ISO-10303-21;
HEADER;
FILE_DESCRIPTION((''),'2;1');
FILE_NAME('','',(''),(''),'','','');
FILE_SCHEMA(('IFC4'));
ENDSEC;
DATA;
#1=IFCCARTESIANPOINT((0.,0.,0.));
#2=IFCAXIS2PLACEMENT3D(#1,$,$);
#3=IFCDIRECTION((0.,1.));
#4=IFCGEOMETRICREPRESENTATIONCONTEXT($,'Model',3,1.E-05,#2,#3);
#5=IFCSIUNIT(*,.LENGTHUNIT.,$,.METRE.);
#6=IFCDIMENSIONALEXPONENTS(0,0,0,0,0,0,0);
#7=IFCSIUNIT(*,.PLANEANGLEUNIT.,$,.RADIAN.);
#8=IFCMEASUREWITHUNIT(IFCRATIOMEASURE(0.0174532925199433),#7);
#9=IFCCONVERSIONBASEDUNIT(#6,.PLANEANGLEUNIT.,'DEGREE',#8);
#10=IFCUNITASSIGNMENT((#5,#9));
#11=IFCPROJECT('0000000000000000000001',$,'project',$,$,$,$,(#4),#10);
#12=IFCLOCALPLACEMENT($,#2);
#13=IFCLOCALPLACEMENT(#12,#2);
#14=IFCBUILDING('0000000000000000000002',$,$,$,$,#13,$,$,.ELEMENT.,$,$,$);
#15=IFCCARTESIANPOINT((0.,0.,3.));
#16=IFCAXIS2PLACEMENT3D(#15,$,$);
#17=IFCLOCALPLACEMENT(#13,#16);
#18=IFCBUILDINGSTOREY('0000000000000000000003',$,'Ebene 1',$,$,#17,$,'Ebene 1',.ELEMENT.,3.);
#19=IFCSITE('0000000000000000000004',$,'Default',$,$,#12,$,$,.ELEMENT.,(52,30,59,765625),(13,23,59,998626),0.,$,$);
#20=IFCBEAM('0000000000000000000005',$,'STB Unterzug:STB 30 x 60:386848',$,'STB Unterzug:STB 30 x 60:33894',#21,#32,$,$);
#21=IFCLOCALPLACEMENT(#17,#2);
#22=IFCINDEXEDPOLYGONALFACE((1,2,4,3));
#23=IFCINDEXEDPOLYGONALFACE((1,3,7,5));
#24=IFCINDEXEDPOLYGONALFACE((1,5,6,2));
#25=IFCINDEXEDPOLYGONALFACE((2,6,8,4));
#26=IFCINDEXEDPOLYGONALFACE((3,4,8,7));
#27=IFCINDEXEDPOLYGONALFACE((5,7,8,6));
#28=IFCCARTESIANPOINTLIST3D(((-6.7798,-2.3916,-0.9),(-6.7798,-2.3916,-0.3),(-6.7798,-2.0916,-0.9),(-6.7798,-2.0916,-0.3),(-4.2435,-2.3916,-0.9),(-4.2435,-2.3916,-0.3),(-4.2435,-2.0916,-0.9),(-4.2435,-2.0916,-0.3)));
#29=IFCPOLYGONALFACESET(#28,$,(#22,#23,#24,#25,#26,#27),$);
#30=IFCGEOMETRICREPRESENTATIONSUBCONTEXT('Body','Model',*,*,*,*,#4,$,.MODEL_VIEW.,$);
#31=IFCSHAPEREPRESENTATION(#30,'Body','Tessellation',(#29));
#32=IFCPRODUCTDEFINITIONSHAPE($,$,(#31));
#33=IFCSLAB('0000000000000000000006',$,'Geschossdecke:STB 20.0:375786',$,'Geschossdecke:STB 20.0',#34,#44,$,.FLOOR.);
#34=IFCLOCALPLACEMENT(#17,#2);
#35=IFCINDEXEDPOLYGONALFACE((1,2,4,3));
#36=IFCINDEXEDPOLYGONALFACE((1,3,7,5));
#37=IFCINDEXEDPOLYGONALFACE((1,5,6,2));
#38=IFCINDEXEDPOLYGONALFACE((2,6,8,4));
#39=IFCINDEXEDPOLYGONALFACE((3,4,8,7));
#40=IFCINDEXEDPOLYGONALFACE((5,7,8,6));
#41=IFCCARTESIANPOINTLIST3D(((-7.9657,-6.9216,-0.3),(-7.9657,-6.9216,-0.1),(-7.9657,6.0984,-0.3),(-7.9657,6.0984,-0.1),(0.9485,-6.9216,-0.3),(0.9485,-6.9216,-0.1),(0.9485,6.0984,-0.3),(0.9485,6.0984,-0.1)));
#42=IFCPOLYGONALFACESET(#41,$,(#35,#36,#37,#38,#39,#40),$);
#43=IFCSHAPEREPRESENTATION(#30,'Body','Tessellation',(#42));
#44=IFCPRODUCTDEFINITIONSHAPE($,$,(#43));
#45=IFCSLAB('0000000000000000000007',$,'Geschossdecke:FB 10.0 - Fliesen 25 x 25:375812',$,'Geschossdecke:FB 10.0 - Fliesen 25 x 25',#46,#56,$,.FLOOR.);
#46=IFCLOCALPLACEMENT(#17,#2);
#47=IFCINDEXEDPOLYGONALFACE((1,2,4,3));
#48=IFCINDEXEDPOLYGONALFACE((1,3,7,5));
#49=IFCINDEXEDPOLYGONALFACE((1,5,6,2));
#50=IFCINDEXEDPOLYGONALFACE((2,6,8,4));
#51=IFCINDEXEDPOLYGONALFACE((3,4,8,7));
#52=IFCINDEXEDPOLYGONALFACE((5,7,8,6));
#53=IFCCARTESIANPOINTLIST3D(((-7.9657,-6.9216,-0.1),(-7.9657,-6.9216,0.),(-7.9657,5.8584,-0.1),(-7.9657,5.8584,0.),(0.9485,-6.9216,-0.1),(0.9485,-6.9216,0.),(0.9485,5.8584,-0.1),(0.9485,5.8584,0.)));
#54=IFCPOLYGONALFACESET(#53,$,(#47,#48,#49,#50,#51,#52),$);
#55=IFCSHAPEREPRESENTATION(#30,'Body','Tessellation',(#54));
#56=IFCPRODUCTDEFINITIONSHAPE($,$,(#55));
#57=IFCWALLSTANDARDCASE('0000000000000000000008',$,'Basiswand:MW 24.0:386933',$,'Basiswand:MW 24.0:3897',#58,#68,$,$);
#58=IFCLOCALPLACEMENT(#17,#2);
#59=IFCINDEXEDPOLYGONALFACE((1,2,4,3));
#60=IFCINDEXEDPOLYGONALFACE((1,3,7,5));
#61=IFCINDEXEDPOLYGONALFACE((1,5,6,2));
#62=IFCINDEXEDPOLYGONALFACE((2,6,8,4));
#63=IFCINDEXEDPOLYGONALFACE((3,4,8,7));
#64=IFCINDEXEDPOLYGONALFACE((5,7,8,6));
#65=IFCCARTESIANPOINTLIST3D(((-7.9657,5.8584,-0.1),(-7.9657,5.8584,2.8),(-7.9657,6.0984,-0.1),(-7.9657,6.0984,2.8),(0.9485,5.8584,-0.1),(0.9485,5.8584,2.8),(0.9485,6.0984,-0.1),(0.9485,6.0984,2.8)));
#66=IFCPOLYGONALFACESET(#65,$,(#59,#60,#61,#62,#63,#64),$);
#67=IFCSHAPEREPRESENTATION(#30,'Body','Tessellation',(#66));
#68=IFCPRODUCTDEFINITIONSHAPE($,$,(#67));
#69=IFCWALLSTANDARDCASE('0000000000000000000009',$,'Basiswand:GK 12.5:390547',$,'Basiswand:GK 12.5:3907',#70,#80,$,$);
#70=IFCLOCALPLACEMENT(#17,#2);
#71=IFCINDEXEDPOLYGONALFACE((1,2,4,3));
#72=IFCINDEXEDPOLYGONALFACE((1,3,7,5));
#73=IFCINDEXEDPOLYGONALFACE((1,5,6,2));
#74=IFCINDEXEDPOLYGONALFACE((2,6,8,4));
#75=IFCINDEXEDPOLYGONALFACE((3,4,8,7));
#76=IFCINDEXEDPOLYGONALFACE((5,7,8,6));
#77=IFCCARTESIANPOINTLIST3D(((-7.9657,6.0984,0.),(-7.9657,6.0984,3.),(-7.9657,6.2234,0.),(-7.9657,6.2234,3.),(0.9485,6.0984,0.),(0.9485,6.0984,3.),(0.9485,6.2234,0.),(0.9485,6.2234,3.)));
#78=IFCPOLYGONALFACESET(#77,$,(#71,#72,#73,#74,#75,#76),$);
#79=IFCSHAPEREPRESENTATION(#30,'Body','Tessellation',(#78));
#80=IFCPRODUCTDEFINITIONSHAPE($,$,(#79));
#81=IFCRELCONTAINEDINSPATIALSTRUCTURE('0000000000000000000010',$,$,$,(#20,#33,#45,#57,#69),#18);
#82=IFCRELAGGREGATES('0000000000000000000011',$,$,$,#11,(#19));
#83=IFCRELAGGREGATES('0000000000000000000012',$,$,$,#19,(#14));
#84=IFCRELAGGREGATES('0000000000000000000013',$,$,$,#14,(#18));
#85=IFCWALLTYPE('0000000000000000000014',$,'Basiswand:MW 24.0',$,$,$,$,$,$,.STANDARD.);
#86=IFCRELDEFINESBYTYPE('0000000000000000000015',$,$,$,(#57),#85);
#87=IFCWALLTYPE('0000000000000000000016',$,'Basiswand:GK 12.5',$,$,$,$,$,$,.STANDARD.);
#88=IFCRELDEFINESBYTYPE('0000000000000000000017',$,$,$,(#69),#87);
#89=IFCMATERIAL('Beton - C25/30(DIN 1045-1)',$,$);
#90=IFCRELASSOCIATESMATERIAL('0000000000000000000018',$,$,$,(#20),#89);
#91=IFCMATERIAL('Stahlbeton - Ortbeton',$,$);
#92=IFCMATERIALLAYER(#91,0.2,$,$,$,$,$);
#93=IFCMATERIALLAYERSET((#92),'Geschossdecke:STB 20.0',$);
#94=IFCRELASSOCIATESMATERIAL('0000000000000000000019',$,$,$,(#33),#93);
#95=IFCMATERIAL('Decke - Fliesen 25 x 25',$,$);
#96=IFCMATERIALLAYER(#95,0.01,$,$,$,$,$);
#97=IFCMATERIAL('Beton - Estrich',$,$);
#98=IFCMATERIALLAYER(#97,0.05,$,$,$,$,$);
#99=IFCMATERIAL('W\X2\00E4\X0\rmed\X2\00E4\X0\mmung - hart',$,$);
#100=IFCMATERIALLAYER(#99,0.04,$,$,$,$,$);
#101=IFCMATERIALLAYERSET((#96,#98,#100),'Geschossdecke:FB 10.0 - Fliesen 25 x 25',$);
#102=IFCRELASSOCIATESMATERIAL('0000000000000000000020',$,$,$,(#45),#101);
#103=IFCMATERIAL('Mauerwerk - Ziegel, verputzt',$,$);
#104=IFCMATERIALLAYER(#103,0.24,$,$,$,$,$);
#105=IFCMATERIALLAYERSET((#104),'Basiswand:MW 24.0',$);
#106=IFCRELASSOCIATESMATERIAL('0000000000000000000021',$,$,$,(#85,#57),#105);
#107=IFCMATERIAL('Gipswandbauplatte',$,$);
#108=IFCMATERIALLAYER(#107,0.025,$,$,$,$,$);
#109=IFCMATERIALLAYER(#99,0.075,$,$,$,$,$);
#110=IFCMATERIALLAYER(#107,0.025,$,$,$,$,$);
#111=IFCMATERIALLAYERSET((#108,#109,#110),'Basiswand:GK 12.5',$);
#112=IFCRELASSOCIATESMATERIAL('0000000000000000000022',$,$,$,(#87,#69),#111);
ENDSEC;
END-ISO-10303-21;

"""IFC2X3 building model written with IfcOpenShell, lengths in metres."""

from ifc_helpers import new_model, entity, si_unit, converted_unit, direction, frame, frame_2d, origin, origin_2d_with_axis, place, context, subcontext, project, spatial, polyline, rectangle, extrude, clip, bounded_halfspace, material, layer, layer_set, layer_usage, type_object, element, save


model = new_model("IFC2X3")

# Units and contexts
model_context = context("Model", 3, precision=1e-05, world=origin(), true_north=direction((0.0, 1.0)))
body_context = subcontext(model_context, "Body", "Model", "MODEL_VIEW")
ifc_project = project(units=[si_unit("LENGTHUNIT", "METRE"), converted_unit("PLANEANGLEUNIT", "DEGREE", entity("IfcRatioMeasure", 0.0174532925199433), si_unit("PLANEANGLEUNIT", "RADIAN"), dimensions=[0, 0, 0, 0, 0, 0, 0])], contexts=[model_context])

# Site, building, storey
site_placement = place(None, origin())
site = spatial("IfcSite", under=ifc_project, at=site_placement, Name="Default", CompositionType="ELEMENT", RefLatitude=(52, 30, 59, 765625), RefLongitude=(13, 23, 59, 998626), RefElevation=0.0)
building_placement = place(site_placement, origin())
building = spatial("IfcBuilding", under=site, at=building_placement, CompositionType="ELEMENT")
storey_placement = place(building_placement, frame((0.0, 0.0, 3.0)))
storey = spatial("IfcBuildingStorey", under=building, at=storey_placement, Name="Ebene 1", LongName="Ebene 1", CompositionType="ELEMENT", Elevation=3.0)

# Beam
ifc_material_1 = material(Name="Beton - C25/30(DIN 1045-1)")
beam_placement = place(storey_placement, frame((-6.7935, -2.2416, -0.3)))
element("IfcBeam", 1, at=beam_placement, inside=storey, material=ifc_material_1, Name="STB Unterzug:STB 30 x 60:386848", ObjectType="STB Unterzug:STB 30 x 60:33894", context=body_context, shape_type="SweptSolid", body=[
    extrude(rectangle(XDim=0.6, YDim=0.3, at=frame_2d((0.0, 0.0), x_axis=(1.0, 0.0))), frame((0.0137, 0.0, -0.3), z_axis=(1.0, 0.0, 0.0), x_axis=(0.0, 0.0, -1.0)), (0.0, 0.0, 1.0), 2.5363),
])

# Slabs
ifc_material_2 = material(Name="Stahlbeton - Ortbeton")
ifc_layer_1 = layer(ifc_material_2, 0.2)
ifc_layer_set_1 = layer_set([ifc_layer_1], Name="Geschossdecke:STB 20.0")
ifc_layer_usage_1 = layer_usage(ifc_layer_set_1, "AXIS3", "POSITIVE", 0.0)
slab_1_placement = place(storey_placement, origin())
element("IfcSlab", 2, at=slab_1_placement, inside=storey, material=ifc_layer_usage_1, Name="Geschossdecke:STB 20.0:375786", ObjectType="Geschossdecke:STB 20.0", PredefinedType="FLOOR", context=body_context, shape_type="SweptSolid", body=[
    extrude(rectangle(XDim=13.02, YDim=8.9141, at=origin_2d_with_axis()), frame((-3.5086, -0.4116, -0.1), z_axis=(0.0, 0.0, -1.0), x_axis=(0.0, 1.0, 0.0)), (0.0, 0.0, 1.0), 0.2),
])
ifc_material_3 = material(Name="Decke - Fliesen 25 x 25")
ifc_layer_2 = layer(ifc_material_3, 0.01)
ifc_material_4 = material(Name="Beton - Estrich")
ifc_layer_3 = layer(ifc_material_4, 0.05)
ifc_material_5 = material(Name="Wärmedämmung - hart")
ifc_layer_4 = layer(ifc_material_5, 0.04)
ifc_layer_set_2 = layer_set([ifc_layer_2, ifc_layer_3, ifc_layer_4], Name="Geschossdecke:FB 10.0 - Fliesen 25 x 25")
ifc_layer_usage_2 = layer_usage(ifc_layer_set_2, "AXIS3", "POSITIVE", 0.0)
slab_2_placement = place(storey_placement, origin())
element("IfcSlab", 3, at=slab_2_placement, inside=storey, material=ifc_layer_usage_2, Name="Geschossdecke:FB 10.0 - Fliesen 25 x 25:375812", ObjectType="Geschossdecke:FB 10.0 - Fliesen 25 x 25", PredefinedType="FLOOR", context=body_context, shape_type="SweptSolid", body=[
    extrude(rectangle(XDim=12.78, YDim=8.9141, at=origin_2d_with_axis()), frame((-3.5086, -0.5316, 0.0), z_axis=(0.0, 0.0, -1.0), x_axis=(0.0, 1.0, 0.0)), (0.0, 0.0, 1.0), 0.1),
])

# Walls
ifc_material_6 = material(Name="Mauerwerk - Ziegel, verputzt")
ifc_layer_5 = layer(ifc_material_6, 0.24)
ifc_layer_set_3 = layer_set([ifc_layer_5], Name="Basiswand:MW 24.0")
ifc_layer_usage_3 = layer_usage(ifc_layer_set_3, "AXIS2", "NEGATIVE", 0.12)
wall_type_1 = type_object("IfcWallType", Name="Basiswand:MW 24.0", PredefinedType="STANDARD", material=ifc_layer_set_3)
wall_1_placement = place(storey_placement, frame((-7.9657, 5.9784, -0.1)))
element("IfcWallStandardCase", 4, at=wall_1_placement, inside=storey, type_object=wall_type_1, material=ifc_layer_usage_3, Name="Basiswand:MW 24.0:386933", ObjectType="Basiswand:MW 24.0:3897", context=body_context, shape_type="Clipping", body=[
    clip(extrude(rectangle(XDim=8.9141, YDim=0.24, at=frame_2d((4.4571, 0.0), x_axis=(-1.0, 0.0))), origin(), (0.0, 0.0, 1.0), 2.9), bounded_halfspace(frame((0.0, -0.12, 2.9), z_axis=(0.0, 0.0, -1.0), x_axis=(0.0, -1.0, 0.0)), True, frame((0.0, -0.12, 2.9)), polyline([(0.0, 0.0), (8.9141, 0.0), (8.9141, 0.24), (0.0, 0.24), (0.0, 0.0)]))),
])
ifc_material_7 = material(Name="Gipswandbauplatte")
ifc_layer_6 = layer(ifc_material_7, 0.025)
ifc_layer_7 = layer(ifc_material_5, 0.075)
ifc_layer_8 = layer(ifc_material_7, 0.025)
ifc_layer_set_4 = layer_set([ifc_layer_6, ifc_layer_7, ifc_layer_8], Name="Basiswand:GK 12.5")
ifc_layer_usage_4 = layer_usage(ifc_layer_set_4, "AXIS2", "NEGATIVE", 0.0625)
wall_type_2 = type_object("IfcWallType", Name="Basiswand:GK 12.5", PredefinedType="STANDARD", material=ifc_layer_set_4)
wall_2_placement = place(storey_placement, frame((-7.9657, 6.1609, 0.0)))
element("IfcWallStandardCase", 5, at=wall_2_placement, inside=storey, type_object=wall_type_2, material=ifc_layer_usage_4, Name="Basiswand:GK 12.5:390547", ObjectType="Basiswand:GK 12.5:3907", context=body_context, shape_type="SweptSolid", body=[
    extrude(rectangle(XDim=8.9141, YDim=0.125, at=frame_2d((4.4571, 0.0), x_axis=(-1.0, 0.0))), origin(), (0.0, 0.0, 1.0), 3.0),
])

save(model, "model.ifc")
